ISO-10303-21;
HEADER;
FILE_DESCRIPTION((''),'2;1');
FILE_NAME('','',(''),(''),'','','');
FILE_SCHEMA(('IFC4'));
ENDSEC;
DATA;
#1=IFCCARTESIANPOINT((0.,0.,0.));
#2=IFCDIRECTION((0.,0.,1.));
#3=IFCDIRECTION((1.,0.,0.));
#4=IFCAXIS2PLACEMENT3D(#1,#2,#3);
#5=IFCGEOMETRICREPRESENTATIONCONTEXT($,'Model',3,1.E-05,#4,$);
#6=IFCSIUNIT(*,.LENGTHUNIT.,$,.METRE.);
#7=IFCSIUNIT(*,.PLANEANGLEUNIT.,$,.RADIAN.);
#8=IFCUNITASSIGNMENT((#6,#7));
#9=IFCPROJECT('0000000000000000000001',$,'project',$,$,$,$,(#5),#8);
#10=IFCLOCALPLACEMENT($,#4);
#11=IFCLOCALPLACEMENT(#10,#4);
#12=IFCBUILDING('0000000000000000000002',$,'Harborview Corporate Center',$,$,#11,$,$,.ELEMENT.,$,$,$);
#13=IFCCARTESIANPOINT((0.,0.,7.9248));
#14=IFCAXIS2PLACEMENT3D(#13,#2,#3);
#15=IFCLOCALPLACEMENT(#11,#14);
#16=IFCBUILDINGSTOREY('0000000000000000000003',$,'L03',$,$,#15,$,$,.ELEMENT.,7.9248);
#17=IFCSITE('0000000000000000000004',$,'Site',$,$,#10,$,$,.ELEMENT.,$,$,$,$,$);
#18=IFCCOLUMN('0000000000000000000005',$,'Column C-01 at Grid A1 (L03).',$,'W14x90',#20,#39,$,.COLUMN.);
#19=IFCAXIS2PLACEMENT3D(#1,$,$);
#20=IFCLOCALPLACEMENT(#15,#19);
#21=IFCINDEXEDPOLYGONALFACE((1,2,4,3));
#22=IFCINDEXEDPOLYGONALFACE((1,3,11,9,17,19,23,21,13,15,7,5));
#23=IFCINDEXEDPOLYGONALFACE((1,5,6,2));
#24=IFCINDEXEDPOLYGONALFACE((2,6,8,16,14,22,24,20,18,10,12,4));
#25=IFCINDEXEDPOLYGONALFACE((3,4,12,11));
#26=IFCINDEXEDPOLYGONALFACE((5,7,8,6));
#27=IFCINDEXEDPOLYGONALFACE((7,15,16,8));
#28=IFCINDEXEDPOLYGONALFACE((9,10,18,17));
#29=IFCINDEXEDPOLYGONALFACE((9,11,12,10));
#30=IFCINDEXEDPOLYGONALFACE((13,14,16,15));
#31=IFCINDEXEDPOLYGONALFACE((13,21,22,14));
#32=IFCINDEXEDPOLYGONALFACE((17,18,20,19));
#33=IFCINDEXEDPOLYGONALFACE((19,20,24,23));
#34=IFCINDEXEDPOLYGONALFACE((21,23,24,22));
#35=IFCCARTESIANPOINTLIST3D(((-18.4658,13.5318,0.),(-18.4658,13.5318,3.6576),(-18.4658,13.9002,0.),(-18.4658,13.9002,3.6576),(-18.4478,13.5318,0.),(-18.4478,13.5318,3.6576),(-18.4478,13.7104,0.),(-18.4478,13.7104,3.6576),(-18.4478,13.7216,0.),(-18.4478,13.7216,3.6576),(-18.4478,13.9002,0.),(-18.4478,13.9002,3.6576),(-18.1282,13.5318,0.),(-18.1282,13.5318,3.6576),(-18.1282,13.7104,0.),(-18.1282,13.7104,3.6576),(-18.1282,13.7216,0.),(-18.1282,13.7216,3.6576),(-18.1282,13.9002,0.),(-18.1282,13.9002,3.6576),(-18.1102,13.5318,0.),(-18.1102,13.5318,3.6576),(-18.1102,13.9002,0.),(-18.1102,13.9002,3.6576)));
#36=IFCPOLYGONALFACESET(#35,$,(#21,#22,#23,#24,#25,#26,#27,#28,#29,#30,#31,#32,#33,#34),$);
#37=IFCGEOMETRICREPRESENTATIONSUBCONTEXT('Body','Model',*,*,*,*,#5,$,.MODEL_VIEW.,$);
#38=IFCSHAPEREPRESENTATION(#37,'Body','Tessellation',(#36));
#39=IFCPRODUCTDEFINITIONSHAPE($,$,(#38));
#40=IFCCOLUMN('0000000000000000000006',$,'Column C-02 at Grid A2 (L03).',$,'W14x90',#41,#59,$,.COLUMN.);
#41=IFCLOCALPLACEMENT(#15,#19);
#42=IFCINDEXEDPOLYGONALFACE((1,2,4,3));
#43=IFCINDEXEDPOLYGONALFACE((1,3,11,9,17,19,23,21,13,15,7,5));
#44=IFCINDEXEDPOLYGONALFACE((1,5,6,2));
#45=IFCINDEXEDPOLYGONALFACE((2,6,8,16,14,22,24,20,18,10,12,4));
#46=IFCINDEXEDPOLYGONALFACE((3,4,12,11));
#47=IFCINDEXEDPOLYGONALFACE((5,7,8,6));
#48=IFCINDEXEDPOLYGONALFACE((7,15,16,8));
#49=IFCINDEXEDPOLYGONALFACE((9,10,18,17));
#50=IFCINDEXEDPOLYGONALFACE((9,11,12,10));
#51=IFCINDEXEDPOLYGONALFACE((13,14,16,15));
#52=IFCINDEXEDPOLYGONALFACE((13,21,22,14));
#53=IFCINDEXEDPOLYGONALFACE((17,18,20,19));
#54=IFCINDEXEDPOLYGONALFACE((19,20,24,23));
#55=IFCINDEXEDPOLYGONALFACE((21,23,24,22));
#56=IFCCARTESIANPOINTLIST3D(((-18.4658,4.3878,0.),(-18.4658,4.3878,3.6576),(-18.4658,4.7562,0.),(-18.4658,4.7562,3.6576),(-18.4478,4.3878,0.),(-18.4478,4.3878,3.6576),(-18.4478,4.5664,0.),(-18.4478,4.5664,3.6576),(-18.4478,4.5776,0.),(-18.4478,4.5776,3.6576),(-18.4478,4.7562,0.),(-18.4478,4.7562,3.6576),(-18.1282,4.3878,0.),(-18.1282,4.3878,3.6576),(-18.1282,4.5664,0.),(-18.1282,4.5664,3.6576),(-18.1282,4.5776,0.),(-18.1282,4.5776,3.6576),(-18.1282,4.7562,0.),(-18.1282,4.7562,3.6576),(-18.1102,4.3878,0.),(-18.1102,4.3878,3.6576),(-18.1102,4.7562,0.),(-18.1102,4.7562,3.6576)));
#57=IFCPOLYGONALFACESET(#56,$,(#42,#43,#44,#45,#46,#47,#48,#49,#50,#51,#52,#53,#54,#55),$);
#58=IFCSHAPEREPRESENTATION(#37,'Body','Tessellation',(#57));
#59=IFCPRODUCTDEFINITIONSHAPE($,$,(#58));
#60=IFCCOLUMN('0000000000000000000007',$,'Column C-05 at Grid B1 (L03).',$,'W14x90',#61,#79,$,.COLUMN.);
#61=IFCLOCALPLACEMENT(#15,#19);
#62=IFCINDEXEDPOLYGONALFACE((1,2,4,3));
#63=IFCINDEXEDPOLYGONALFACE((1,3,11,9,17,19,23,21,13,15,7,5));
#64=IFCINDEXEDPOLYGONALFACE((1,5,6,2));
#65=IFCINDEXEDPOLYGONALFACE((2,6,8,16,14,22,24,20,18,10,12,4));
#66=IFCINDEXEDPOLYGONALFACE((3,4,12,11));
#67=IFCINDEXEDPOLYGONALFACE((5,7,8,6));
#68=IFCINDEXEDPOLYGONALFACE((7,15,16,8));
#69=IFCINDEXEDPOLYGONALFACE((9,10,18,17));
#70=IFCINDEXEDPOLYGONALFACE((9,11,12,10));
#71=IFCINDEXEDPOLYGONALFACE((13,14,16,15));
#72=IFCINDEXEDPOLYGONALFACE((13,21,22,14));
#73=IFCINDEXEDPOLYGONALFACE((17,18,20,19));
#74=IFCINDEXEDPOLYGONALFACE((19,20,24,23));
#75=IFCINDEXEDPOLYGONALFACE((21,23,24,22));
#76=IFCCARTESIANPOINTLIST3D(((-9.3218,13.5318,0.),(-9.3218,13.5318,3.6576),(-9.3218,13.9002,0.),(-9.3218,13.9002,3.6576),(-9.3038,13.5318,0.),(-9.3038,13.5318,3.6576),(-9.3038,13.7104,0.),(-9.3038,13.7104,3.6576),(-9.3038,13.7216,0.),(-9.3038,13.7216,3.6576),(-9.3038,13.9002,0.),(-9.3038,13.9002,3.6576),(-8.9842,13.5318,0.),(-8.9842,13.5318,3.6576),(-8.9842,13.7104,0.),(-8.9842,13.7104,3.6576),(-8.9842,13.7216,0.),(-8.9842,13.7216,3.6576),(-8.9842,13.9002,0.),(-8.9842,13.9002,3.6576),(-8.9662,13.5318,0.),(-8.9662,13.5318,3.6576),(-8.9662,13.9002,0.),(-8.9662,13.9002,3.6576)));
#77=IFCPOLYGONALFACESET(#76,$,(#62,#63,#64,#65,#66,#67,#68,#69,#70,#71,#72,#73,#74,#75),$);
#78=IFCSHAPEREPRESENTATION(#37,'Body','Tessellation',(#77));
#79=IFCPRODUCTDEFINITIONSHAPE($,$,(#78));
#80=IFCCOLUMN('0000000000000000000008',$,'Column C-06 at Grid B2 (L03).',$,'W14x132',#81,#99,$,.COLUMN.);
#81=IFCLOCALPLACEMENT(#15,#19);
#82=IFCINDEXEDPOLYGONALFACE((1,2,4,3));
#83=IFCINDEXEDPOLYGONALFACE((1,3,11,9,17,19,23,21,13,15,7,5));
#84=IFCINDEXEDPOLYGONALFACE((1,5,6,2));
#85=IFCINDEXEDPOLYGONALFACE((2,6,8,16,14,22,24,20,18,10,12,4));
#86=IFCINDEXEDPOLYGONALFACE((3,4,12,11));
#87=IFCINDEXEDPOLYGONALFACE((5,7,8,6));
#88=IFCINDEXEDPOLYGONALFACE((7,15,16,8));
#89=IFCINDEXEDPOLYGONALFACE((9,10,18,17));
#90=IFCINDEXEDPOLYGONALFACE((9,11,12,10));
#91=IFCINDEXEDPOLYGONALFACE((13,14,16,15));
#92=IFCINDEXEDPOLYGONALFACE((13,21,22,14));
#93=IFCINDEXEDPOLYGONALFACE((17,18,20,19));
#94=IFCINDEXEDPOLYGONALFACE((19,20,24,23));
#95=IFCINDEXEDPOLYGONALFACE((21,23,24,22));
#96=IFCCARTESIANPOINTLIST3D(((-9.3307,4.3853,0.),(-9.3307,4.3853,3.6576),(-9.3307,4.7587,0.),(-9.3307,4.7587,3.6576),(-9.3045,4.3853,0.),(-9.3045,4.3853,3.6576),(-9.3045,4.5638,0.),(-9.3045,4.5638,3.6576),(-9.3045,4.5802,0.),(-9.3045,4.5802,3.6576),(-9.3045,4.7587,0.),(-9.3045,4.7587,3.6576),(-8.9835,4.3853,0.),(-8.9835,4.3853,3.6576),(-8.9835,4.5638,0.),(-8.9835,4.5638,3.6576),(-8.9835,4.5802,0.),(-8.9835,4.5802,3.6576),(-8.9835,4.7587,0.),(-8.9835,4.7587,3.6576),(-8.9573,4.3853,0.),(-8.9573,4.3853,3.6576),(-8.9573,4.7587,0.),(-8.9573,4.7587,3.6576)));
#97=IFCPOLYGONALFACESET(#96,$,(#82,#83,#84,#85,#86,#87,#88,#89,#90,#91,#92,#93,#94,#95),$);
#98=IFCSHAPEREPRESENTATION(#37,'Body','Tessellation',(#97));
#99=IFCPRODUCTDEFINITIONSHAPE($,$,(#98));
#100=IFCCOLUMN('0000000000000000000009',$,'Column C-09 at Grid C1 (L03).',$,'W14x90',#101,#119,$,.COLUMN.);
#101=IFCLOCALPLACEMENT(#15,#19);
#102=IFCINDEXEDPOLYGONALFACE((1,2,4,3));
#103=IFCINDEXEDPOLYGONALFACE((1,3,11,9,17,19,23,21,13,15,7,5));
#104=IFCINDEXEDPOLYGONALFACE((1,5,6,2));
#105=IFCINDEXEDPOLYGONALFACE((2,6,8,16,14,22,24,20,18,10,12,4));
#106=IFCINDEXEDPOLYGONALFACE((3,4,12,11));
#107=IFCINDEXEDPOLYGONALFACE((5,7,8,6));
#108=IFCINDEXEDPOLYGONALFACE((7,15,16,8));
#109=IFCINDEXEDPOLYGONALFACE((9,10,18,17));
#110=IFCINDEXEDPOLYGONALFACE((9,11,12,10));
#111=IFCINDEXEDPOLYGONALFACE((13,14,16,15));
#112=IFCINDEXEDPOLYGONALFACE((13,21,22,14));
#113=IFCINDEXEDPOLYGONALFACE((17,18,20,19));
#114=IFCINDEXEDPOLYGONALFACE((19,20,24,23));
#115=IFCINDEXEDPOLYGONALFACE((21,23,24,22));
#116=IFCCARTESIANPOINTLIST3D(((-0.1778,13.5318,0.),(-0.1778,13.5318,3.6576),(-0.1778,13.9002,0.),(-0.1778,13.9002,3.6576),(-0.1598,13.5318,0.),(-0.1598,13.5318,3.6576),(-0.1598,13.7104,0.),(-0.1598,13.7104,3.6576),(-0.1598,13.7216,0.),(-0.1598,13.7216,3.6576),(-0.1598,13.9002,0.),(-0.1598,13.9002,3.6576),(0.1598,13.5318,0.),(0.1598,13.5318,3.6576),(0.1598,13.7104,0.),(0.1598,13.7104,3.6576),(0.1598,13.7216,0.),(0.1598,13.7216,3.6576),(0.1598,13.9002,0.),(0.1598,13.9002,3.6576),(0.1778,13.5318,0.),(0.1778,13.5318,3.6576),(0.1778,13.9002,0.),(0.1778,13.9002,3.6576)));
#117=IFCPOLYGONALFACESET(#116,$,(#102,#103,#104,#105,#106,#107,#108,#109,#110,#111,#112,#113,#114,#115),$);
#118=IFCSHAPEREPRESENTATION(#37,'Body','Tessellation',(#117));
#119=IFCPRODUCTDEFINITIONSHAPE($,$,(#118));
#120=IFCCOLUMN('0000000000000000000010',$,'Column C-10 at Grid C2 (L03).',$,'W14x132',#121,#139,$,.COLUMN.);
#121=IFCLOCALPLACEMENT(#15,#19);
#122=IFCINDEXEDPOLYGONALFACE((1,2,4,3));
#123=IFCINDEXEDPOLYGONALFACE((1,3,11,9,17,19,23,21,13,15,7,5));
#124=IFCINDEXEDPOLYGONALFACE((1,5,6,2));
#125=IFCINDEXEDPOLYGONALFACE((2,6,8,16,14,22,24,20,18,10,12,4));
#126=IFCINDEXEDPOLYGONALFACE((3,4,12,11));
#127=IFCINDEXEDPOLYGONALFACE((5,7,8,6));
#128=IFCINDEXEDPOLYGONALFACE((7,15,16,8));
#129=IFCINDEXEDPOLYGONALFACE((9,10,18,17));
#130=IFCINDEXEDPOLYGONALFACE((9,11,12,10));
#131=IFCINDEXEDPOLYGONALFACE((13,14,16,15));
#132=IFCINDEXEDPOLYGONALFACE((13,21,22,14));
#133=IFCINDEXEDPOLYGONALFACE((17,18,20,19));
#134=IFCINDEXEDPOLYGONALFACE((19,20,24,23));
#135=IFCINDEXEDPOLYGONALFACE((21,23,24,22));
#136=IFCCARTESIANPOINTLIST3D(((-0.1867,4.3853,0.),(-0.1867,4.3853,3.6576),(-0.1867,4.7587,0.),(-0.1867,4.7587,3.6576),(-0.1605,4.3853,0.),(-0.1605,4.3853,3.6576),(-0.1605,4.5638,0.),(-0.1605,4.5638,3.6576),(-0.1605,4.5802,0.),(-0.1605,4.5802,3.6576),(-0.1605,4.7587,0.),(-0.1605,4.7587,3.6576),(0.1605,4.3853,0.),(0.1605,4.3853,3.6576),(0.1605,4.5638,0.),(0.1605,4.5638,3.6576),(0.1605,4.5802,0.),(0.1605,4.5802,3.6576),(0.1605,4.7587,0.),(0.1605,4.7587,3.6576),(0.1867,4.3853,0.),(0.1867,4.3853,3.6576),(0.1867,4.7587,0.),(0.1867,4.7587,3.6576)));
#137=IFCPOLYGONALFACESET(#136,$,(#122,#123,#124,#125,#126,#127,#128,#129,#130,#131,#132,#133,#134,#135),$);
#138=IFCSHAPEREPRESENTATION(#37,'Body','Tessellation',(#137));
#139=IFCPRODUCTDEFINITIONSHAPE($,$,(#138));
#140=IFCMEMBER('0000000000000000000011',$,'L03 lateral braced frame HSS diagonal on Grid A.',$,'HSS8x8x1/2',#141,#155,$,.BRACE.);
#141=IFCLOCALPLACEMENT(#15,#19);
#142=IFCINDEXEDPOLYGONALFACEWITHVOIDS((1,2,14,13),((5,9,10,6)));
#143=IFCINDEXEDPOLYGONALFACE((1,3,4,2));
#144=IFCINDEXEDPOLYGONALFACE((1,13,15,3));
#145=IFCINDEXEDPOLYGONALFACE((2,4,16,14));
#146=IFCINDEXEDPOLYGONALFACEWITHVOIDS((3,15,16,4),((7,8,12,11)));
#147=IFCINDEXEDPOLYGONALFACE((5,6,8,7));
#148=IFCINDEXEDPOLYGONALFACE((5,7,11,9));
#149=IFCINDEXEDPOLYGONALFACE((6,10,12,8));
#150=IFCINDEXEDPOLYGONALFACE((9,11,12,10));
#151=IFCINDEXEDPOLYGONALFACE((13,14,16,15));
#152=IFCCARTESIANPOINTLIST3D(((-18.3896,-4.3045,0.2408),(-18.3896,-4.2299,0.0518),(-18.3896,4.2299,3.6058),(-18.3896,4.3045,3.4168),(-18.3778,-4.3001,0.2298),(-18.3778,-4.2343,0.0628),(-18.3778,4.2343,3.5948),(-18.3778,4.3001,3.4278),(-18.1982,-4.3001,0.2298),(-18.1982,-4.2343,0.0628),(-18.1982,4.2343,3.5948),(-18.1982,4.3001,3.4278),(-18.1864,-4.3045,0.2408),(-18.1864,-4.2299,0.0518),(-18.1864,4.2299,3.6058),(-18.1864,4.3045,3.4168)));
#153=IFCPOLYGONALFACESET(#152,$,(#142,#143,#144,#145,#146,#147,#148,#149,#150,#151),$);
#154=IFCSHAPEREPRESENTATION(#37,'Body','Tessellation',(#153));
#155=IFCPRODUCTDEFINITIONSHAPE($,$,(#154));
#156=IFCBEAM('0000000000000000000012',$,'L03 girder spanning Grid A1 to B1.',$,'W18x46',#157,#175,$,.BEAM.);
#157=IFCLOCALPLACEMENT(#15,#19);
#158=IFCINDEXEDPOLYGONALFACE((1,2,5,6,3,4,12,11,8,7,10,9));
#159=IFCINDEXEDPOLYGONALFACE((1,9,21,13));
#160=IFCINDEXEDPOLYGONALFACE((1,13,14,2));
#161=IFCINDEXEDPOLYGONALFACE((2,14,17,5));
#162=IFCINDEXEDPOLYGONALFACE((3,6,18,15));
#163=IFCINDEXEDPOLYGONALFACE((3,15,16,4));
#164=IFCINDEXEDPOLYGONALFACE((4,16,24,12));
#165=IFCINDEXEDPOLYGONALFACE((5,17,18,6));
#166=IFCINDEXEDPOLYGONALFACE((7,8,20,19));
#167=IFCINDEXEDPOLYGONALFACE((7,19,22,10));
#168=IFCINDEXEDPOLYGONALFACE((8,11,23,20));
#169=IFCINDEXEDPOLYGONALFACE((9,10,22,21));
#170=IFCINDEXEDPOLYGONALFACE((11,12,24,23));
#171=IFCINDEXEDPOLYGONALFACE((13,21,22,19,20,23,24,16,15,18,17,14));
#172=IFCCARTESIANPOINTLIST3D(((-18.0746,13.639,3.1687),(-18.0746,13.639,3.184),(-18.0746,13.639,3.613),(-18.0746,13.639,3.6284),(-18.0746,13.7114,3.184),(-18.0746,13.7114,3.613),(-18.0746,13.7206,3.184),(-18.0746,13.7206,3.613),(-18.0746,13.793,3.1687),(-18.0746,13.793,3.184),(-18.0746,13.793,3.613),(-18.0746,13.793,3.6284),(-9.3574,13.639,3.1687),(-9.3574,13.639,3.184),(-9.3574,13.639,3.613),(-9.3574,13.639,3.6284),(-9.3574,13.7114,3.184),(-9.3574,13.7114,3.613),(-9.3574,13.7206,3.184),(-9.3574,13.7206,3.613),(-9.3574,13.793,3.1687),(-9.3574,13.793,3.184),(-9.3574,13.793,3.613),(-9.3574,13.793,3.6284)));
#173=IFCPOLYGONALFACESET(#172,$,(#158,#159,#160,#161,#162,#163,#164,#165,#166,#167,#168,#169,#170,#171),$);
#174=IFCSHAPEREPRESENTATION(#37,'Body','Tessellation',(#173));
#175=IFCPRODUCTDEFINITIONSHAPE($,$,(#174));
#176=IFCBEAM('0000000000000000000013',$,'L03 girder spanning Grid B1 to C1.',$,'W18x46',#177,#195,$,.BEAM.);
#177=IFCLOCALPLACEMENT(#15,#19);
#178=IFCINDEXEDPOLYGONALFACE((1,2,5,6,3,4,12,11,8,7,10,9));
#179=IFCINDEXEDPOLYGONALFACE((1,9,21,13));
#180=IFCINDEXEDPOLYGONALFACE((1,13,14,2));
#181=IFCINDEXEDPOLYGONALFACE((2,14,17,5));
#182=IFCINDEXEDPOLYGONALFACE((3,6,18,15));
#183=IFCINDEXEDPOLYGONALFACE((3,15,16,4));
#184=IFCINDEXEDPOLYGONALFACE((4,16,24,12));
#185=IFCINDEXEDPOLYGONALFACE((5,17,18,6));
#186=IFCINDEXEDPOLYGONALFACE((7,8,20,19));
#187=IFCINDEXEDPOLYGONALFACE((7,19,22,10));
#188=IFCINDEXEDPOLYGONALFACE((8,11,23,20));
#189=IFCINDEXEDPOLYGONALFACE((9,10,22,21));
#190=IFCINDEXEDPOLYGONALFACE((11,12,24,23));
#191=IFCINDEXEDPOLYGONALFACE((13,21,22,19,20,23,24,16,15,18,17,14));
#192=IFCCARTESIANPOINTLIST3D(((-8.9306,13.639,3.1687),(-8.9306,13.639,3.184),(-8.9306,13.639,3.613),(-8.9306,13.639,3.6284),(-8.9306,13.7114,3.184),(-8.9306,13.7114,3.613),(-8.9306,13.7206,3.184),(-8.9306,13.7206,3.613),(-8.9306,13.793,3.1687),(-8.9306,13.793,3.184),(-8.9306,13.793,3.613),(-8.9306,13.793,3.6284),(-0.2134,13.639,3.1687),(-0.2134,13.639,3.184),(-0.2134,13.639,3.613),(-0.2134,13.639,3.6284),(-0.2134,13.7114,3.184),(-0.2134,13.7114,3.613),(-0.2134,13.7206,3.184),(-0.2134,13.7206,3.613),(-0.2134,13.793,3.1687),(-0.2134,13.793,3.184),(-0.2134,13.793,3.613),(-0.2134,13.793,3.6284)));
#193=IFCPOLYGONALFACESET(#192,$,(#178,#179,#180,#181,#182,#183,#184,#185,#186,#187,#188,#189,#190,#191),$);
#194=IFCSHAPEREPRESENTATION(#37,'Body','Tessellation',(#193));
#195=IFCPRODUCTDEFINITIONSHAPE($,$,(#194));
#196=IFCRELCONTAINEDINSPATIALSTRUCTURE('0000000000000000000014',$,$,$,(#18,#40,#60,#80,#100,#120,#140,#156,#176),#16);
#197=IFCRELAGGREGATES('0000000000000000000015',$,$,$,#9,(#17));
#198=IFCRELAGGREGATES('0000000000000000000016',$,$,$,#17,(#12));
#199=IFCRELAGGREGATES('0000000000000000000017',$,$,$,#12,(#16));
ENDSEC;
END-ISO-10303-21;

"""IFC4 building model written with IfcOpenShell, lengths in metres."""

from ifc_helpers import new_model, si_unit, frame, origin_with_axes, place, context, subcontext, project, spatial, hollow_rectangle, i_section, extrude, element, save


model = new_model("IFC4")

# Units and contexts
model_context = context("Model", 3, precision=1e-05, world=origin_with_axes())
body_context = subcontext(model_context, "Body", "Model", "MODEL_VIEW")
ifc_project = project(units=[si_unit("LENGTHUNIT", "METRE"), si_unit("PLANEANGLEUNIT", "RADIAN")], contexts=[model_context])

# Site, building, storey
site_placement = place(None, origin_with_axes())
site = spatial("IfcSite", under=ifc_project, at=site_placement, Name="Site", CompositionType="ELEMENT")
building_placement = place(site_placement, origin_with_axes())
building = spatial("IfcBuilding", under=site, at=building_placement, Name="Harborview Corporate Center", CompositionType="ELEMENT")
storey_placement = place(building_placement, frame((0.0, 0.0, 7.9248), z_axis=(0.0, 0.0, 1.0), x_axis=(1.0, 0.0, 0.0)))
storey = spatial("IfcBuildingStorey", under=building, at=storey_placement, Name="L03", CompositionType="ELEMENT", Elevation=7.9248)

# Columns
for number, where, z_axis, x_axis, name in (
    (1, (-18.288, 13.716, 0.0), (0.0, 0.0, 1.0), (0.0, 1.0, 0.0), "Column C-01 at Grid A1 (L03)."),
    (2, (-18.288, 4.572, 0.0), (0.0, 0.0, 1.0), (0.0, 1.0, 0.0), "Column C-02 at Grid A2 (L03)."),
    (3, (-9.144, 13.716, 0.0), (0.0, 0.0, 1.0), (0.0, 1.0, 0.0), "Column C-05 at Grid B1 (L03)."),
):
    element("IfcColumn", number, at=place(storey_placement, frame(where, z_axis=z_axis, x_axis=x_axis)), inside=storey, Name=name, ObjectType="W14x90", PredefinedType="COLUMN", context=body_context, shape_type="SweptSolid", body=[
        extrude(i_section(OverallWidth=0.3683, OverallDepth=0.3556, WebThickness=0.0112, FlangeThickness=0.018), origin_with_axes(), (0.0, 0.0, 1.0), 3.6576),
    ])
column_1_placement = place(storey_placement, frame((-9.144, 4.572, 0.0), z_axis=(0.0, 0.0, 1.0), x_axis=(0.0, 1.0, 0.0)))
element("IfcColumn", 4, at=column_1_placement, inside=storey, Name="Column C-06 at Grid B2 (L03).", ObjectType="W14x132", PredefinedType="COLUMN", context=body_context, shape_type="SweptSolid", body=[
    extrude(i_section(OverallWidth=0.3734, OverallDepth=0.3734, WebThickness=0.0164, FlangeThickness=0.0262), origin_with_axes(), (0.0, 0.0, 1.0), 3.6576),
])
column_2_placement = place(storey_placement, frame((0.0, 13.716, 0.0), z_axis=(0.0, 0.0, 1.0), x_axis=(0.0, 1.0, 0.0)))
element("IfcColumn", 5, at=column_2_placement, inside=storey, Name="Column C-09 at Grid C1 (L03).", ObjectType="W14x90", PredefinedType="COLUMN", context=body_context, shape_type="SweptSolid", body=[
    extrude(i_section(OverallWidth=0.3683, OverallDepth=0.3556, WebThickness=0.0112, FlangeThickness=0.018), origin_with_axes(), (0.0, 0.0, 1.0), 3.6576),
])
column_3_placement = place(storey_placement, frame((0.0, 4.572, 0.0), z_axis=(0.0, 0.0, 1.0), x_axis=(0.0, 1.0, 0.0)))
element("IfcColumn", 6, at=column_3_placement, inside=storey, Name="Column C-10 at Grid C2 (L03).", ObjectType="W14x132", PredefinedType="COLUMN", context=body_context, shape_type="SweptSolid", body=[
    extrude(i_section(OverallWidth=0.3734, OverallDepth=0.3734, WebThickness=0.0164, FlangeThickness=0.0262), origin_with_axes(), (0.0, 0.0, 1.0), 3.6576),
])

# Member
member_placement = place(storey_placement, frame((-18.288, -4.2672, 0.1463), z_axis=(0.0, 0.930298, 0.366803), x_axis=(-1.0, 0.0, 0.0)))
element("IfcMember", 7, at=member_placement, inside=storey, Name="L03 lateral braced frame HSS diagonal on Grid A.", ObjectType="HSS8x8x1/2", PredefinedType="BRACE", context=body_context, shape_type="SweptSolid", body=[
    extrude(hollow_rectangle(XDim=0.2032, YDim=0.2032, WallThickness=0.0118), origin_with_axes(), (0.0, 0.0, 1.0), 9.1738),
])

# Beams
beam_1_placement = place(storey_placement, frame((-18.0746, 13.716, 3.3985), z_axis=(1.0, 0.0, 0.0), x_axis=(0.0, 1.0, 0.0)))
element("IfcBeam", 8, at=beam_1_placement, inside=storey, Name="L03 girder spanning Grid A1 to B1.", ObjectType="W18x46", PredefinedType="BEAM", context=body_context, shape_type="SweptSolid", body=[
    extrude(i_section(OverallWidth=0.1539, OverallDepth=0.4597, WebThickness=0.0091, FlangeThickness=0.0154), origin_with_axes(), (0.0, 0.0, 1.0), 8.7173),
])
beam_2_placement = place(storey_placement, frame((-8.9306, 13.716, 3.3985), z_axis=(1.0, 0.0, 0.0), x_axis=(0.0, 1.0, 0.0)))
element("IfcBeam", 9, at=beam_2_placement, inside=storey, Name="L03 girder spanning Grid B1 to C1.", ObjectType="W18x46", PredefinedType="BEAM", context=body_context, shape_type="SweptSolid", body=[
    extrude(i_section(OverallWidth=0.1539, OverallDepth=0.4597, WebThickness=0.0091, FlangeThickness=0.0154), origin_with_axes(), (0.0, 0.0, 1.0), 8.7173),
])

save(model, "model.ifc")
